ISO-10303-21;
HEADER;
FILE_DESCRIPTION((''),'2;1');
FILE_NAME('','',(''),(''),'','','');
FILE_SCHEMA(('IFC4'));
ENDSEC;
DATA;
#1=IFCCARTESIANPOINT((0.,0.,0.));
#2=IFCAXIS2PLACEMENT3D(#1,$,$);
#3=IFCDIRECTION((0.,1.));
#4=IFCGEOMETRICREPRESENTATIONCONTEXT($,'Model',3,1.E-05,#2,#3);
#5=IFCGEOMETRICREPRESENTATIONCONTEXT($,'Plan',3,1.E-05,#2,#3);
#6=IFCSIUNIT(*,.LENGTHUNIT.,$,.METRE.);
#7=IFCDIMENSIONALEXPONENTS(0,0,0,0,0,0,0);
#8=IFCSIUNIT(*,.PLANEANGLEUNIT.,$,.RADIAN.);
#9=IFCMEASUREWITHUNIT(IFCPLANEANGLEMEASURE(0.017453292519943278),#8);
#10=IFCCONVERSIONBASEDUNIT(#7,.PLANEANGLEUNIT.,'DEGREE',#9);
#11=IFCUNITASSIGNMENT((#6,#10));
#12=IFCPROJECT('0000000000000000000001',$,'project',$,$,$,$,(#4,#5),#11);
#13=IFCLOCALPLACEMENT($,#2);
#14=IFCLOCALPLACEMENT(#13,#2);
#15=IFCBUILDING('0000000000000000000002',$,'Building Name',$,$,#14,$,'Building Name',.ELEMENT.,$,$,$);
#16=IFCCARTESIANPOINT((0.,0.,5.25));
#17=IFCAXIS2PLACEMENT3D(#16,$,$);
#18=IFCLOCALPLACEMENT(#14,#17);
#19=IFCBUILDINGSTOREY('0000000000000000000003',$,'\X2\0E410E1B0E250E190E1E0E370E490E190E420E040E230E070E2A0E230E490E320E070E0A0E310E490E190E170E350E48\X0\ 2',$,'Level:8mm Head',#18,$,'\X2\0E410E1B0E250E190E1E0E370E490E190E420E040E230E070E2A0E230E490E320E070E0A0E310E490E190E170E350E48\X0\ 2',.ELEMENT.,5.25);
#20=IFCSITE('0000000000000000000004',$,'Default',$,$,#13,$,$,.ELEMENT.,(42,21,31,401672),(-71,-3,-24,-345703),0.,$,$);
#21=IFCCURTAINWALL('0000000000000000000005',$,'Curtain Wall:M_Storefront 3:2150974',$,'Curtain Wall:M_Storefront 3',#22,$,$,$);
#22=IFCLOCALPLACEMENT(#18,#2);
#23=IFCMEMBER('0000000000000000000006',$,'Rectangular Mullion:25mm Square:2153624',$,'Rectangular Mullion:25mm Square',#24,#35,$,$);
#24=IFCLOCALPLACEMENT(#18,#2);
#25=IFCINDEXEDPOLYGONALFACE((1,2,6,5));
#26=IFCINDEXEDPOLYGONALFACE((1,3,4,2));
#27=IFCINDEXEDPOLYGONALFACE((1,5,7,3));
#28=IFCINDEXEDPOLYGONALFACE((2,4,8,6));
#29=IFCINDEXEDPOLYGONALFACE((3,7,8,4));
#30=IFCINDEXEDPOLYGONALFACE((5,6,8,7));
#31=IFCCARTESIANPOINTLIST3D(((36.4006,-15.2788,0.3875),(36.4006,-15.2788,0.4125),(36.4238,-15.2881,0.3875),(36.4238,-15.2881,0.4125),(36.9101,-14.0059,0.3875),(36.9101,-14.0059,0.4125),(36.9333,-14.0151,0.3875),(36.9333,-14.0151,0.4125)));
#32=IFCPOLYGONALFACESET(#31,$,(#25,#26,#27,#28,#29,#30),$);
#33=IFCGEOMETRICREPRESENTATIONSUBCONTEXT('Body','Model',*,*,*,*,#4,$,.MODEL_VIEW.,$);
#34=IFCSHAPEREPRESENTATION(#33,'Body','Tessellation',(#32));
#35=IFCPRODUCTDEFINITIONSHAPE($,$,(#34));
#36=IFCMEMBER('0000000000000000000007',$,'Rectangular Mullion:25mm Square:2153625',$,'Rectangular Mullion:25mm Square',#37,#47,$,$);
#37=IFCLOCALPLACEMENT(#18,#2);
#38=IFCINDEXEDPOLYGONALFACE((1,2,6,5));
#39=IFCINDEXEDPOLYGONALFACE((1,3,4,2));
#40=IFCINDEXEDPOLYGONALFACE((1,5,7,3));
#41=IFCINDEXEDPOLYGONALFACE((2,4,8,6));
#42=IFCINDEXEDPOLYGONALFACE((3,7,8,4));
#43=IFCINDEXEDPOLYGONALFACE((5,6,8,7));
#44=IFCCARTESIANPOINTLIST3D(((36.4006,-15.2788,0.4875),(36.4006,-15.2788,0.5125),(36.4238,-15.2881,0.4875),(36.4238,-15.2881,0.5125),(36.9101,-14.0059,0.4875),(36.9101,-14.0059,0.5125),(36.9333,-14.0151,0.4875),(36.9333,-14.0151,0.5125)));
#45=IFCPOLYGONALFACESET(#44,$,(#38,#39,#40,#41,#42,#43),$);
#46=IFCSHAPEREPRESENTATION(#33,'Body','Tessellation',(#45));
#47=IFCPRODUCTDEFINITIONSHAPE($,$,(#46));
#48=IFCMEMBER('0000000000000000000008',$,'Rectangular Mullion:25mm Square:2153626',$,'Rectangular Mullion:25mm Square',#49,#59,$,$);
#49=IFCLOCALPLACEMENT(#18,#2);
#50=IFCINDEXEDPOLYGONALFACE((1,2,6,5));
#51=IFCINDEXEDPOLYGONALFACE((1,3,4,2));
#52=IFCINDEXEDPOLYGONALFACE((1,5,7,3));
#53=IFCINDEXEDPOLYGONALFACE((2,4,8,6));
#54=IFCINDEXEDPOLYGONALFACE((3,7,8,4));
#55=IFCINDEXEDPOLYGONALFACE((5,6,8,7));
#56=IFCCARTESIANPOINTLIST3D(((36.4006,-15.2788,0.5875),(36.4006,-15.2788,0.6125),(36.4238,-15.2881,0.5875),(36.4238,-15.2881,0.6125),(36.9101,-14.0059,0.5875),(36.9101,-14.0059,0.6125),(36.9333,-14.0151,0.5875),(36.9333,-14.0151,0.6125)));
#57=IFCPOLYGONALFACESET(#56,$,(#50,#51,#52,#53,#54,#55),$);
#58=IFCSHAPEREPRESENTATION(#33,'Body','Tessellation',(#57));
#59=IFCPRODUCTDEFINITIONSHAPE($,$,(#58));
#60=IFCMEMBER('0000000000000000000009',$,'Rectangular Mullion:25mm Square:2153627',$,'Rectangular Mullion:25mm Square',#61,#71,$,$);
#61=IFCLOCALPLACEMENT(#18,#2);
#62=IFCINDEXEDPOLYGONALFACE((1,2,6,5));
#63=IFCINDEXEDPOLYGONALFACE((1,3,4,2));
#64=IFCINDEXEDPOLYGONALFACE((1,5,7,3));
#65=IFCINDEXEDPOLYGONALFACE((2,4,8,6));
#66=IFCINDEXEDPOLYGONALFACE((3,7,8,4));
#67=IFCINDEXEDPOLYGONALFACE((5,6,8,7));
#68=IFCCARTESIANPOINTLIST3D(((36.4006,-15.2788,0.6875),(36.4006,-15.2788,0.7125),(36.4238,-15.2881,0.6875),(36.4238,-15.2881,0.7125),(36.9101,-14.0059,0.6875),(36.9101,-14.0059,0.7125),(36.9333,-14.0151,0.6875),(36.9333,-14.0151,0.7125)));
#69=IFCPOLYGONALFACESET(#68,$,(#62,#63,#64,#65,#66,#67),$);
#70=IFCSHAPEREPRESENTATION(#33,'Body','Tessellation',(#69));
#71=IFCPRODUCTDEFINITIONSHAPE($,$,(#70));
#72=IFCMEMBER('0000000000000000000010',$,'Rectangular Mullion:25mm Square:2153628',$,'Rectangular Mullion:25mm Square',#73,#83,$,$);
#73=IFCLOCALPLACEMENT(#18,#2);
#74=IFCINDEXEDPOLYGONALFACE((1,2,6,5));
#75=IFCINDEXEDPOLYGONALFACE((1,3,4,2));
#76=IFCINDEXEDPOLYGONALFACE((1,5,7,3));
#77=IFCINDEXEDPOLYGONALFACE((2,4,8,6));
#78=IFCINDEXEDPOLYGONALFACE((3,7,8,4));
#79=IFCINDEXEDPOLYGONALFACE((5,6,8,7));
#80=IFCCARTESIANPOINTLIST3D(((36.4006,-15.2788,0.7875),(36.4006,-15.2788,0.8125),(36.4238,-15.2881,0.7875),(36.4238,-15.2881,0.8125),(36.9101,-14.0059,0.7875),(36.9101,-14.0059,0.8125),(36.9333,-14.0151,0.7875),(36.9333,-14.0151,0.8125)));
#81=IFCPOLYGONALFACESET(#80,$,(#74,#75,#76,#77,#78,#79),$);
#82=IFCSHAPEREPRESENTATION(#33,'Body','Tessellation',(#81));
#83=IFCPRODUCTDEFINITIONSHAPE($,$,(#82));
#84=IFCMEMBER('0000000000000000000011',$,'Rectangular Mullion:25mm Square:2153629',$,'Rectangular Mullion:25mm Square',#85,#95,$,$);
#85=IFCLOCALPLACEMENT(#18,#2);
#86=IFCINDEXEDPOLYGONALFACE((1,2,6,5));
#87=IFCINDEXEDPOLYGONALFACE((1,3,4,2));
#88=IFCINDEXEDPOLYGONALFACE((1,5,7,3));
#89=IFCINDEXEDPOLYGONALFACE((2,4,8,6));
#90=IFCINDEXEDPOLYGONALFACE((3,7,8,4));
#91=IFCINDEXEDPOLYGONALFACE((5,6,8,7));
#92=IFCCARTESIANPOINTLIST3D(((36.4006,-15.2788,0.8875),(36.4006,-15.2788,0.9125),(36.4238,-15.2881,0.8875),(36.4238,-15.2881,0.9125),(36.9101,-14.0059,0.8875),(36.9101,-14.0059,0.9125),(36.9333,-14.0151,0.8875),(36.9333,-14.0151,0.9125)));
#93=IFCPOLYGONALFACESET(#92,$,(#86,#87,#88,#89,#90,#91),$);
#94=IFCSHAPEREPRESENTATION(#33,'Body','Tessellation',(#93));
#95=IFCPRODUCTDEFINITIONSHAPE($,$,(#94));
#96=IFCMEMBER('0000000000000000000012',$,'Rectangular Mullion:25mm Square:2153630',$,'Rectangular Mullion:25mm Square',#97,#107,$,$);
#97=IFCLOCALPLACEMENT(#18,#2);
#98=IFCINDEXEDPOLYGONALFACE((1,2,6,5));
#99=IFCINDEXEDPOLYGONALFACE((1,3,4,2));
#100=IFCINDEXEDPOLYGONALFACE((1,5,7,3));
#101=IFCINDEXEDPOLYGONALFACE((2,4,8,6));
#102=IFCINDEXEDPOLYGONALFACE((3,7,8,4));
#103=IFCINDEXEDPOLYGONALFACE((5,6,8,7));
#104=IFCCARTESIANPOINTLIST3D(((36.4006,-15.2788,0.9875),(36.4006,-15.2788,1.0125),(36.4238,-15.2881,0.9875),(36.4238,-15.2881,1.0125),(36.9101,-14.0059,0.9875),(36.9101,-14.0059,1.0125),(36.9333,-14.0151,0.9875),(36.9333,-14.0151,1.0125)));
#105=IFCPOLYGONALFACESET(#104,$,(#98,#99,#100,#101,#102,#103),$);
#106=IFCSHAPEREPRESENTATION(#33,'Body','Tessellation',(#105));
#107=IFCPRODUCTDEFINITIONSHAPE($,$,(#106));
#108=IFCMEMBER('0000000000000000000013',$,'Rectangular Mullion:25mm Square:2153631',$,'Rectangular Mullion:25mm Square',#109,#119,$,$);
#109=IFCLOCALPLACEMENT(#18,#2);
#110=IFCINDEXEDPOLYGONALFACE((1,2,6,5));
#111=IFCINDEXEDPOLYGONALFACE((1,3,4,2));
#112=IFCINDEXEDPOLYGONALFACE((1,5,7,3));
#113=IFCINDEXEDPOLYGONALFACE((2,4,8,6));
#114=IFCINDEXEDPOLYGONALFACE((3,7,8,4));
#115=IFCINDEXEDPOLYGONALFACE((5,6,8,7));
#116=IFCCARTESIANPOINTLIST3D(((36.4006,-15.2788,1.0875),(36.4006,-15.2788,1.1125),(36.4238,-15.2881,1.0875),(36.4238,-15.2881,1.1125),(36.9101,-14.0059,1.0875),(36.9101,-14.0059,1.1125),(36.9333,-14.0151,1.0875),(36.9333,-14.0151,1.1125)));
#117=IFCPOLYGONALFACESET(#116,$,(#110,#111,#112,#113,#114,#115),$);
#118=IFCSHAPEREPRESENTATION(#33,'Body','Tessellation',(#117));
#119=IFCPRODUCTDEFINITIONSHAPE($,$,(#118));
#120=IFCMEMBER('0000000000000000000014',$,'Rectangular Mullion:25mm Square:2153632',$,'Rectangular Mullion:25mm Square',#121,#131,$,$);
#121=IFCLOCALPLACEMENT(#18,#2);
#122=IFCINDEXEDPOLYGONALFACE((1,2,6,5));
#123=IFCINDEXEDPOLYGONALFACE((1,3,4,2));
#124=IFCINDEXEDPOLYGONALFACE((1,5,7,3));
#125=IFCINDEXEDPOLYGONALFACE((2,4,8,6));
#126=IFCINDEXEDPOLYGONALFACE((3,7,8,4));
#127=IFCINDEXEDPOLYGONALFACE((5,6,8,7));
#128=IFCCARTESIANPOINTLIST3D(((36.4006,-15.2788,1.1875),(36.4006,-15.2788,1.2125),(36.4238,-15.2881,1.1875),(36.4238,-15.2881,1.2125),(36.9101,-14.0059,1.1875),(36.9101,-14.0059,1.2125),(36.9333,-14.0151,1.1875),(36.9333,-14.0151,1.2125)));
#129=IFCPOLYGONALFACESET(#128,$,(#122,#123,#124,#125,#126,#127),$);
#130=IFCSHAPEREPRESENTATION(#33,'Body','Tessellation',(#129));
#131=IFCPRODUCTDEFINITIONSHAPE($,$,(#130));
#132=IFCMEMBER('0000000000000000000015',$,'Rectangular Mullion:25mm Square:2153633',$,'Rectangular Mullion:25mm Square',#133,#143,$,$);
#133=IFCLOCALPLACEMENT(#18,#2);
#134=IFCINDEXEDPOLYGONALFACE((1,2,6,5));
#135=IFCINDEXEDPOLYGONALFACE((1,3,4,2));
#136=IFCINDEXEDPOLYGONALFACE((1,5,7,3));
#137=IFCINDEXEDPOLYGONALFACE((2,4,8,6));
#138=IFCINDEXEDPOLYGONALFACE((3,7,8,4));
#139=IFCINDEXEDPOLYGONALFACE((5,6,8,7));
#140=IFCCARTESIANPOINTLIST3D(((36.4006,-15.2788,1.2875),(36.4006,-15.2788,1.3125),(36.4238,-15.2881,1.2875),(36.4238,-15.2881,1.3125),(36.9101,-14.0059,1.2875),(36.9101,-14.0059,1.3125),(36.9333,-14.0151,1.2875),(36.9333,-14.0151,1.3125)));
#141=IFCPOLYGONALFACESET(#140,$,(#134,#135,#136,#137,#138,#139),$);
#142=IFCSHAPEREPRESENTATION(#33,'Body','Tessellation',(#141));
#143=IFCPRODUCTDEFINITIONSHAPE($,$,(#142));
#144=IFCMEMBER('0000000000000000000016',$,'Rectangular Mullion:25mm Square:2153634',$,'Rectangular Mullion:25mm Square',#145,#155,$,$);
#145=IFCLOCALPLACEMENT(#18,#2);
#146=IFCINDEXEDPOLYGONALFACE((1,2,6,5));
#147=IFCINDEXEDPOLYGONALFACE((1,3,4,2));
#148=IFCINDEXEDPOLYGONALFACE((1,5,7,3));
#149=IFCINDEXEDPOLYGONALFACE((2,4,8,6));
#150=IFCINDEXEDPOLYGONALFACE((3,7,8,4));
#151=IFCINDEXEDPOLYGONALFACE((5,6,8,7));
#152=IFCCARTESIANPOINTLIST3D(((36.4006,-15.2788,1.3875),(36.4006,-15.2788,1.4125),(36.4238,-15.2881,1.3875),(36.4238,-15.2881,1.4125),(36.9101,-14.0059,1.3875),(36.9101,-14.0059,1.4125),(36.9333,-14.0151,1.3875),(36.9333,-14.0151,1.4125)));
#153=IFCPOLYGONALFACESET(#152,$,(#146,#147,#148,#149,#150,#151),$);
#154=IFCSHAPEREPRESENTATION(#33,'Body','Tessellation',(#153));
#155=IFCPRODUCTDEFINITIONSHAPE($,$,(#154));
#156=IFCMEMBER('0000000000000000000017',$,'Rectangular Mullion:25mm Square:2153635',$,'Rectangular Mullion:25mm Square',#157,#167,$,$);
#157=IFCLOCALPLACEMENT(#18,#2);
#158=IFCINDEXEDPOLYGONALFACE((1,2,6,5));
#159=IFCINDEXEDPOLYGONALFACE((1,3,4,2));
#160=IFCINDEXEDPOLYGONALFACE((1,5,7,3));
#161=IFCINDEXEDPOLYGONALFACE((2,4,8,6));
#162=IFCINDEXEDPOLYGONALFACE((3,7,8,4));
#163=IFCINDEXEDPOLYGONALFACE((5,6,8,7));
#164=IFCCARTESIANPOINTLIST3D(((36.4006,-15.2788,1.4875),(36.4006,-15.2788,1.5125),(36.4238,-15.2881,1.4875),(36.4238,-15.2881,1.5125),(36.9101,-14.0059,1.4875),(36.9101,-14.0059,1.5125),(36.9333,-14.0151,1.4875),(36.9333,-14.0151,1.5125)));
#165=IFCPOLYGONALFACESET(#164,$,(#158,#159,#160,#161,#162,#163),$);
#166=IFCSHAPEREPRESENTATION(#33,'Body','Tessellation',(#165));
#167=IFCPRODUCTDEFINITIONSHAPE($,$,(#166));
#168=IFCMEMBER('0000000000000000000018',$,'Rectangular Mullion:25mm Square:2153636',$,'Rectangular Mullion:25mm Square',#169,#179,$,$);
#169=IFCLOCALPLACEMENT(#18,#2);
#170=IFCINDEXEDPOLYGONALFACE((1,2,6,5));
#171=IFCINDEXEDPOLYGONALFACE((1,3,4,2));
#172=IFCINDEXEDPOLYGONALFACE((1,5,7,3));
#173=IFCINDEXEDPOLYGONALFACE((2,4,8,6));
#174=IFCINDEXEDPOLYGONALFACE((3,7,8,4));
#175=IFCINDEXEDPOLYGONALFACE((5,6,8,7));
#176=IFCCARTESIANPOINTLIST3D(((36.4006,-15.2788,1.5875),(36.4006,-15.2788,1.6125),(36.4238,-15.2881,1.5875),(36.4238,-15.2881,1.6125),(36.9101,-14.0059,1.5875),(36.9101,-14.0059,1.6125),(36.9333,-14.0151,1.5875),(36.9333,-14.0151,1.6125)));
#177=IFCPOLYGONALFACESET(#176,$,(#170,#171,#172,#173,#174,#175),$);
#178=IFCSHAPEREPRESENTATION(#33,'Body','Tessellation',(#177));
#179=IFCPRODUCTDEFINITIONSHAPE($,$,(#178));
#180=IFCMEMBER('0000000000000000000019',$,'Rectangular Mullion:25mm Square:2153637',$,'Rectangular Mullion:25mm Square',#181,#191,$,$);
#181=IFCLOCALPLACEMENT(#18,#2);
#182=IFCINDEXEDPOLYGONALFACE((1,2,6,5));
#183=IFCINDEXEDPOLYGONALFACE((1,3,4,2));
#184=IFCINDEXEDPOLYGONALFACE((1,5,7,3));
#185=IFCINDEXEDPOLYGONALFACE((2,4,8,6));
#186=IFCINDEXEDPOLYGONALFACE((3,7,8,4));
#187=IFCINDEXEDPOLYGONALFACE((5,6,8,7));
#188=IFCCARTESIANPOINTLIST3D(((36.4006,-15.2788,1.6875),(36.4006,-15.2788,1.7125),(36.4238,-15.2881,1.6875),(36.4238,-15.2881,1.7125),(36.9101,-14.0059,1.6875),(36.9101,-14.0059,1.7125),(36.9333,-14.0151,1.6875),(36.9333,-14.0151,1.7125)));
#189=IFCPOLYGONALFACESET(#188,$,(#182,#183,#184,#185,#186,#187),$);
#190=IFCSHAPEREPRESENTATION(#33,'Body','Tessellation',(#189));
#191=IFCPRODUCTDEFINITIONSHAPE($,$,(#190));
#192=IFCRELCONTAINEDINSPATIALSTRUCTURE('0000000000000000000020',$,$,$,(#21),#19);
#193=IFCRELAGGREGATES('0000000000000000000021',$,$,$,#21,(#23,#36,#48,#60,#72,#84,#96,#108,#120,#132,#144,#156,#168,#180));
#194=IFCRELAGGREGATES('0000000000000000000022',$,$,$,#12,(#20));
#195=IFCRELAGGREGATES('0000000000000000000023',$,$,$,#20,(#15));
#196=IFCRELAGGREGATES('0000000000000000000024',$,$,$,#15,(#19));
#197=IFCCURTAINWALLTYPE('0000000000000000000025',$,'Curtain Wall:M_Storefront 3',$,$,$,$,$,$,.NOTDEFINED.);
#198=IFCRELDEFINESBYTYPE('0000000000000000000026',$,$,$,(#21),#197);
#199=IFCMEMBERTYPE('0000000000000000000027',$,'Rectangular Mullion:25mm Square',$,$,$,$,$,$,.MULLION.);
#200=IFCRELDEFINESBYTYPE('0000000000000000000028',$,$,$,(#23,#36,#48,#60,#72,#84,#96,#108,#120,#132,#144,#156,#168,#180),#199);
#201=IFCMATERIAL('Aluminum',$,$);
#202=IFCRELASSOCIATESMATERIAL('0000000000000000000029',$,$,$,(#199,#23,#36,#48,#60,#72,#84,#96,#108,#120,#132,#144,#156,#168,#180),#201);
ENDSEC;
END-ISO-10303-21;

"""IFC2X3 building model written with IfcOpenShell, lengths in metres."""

from ifc_helpers import new_model, entity, si_unit, converted_unit, direction, frame, frame_2d, origin, place, context, subcontext, project, spatial, rectangle, extrude, source, transform, mapped, material, type_object, type_shapes, element, aggregate, save


model = new_model("IFC2X3")

# Units and contexts
model_context = context("Model", 3, precision=1e-05, world=origin(), true_north=direction((0.0, 1.0)))
plan_context = context("Plan", 3, precision=1e-05, world=origin(), true_north=direction((0.0, 1.0)))
body_context = subcontext(model_context, "Body", "Model", "MODEL_VIEW")
ifc_project = project(units=[si_unit("LENGTHUNIT", "METRE"), converted_unit("PLANEANGLEUNIT", "DEGREE", entity("IfcPlaneAngleMeasure", 0.017453292519943278), si_unit("PLANEANGLEUNIT", "RADIAN"), dimensions=[0, 0, 0, 0, 0, 0, 0])], contexts=[model_context, plan_context])

# Site, building, storey
site_placement = place(None, origin())
site = spatial("IfcSite", under=ifc_project, at=site_placement, Name="Default", CompositionType="ELEMENT", RefLatitude=(42, 21, 31, 401672), RefLongitude=(-71, -3, -24, -345703), RefElevation=0.0)
building_placement = place(site_placement, origin())
building = spatial("IfcBuilding", under=site, at=building_placement, Name="Building Name", LongName="Building Name", CompositionType="ELEMENT")
storey_placement = place(building_placement, frame((0.0, 0.0, 5.25)))
storey = spatial("IfcBuildingStorey", under=building, at=storey_placement, Name="แปลนพื้นโครงสร้างชั้นที่ 2", ObjectType="Level:8mm Head", LongName="แปลนพื้นโครงสร้างชั้นที่ 2", CompositionType="ELEMENT", Elevation=5.25)

# Curtain wall, members
curtain_wall_type = type_object("IfcCurtainWallType", Name="Curtain Wall:M_Storefront 3", PredefinedType="NOTDEFINED")
curtain_wall_placement = place(storey_placement, frame((0.0, 0.0, -5.25)))
curtain_wall = element("IfcCurtainWall", 1, at=curtain_wall_placement, inside=storey, type_object=curtain_wall_type, Name="Curtain Wall:M_Storefront 3:2150974", ObjectType="Curtain Wall:M_Storefront 3")
ifc_material_1 = material(Name="Aluminum")
member_type_1 = type_object("IfcMemberType", Name="Rectangular Mullion:25mm Square", PredefinedType="MULLION", material=ifc_material_1)
shared_shape_1 = source(origin(), body_context, "Body", "SweptSolid", [
    extrude(rectangle(XDim=0.025, YDim=0.025, at=frame_2d((0.0, 0.0), x_axis=(1.0, 0.0))), frame((0.0, 0.0, -1.3712), z_axis=(0.0, 0.0, 1.0), x_axis=(-1.0, 0.0, 0.0)), (0.0, 0.0, 1.0), 1.3712),
])
type_shapes(member_type_1, [shared_shape_1])
member_1_placement = place(curtain_wall_placement, frame((36.9217, -14.0105, 5.65), z_axis=(0.371573, 0.928404, 0.0), x_axis=(0.0, 0.0, 1.0)))
member_1 = element("IfcMember", 2, at=member_1_placement, type_object=member_type_1, material=ifc_material_1, Name="Rectangular Mullion:25mm Square:2153624", ObjectType="Rectangular Mullion:25mm Square", context=body_context, shape_type="MappedRepresentation", body=[
    mapped(shared_shape_1, transform((0.0, 0.0, 0.0), scale=1.0)),
])
member_2_placement = place(curtain_wall_placement, frame((36.9217, -14.0105, 5.75), z_axis=(0.371573, 0.928404, 0.0), x_axis=(0.0, 0.0, 1.0)))
member_2 = element("IfcMember", 3, at=member_2_placement, type_object=member_type_1, material=ifc_material_1, Name="Rectangular Mullion:25mm Square:2153625", ObjectType="Rectangular Mullion:25mm Square", context=body_context, shape_type="MappedRepresentation", body=[
    mapped(shared_shape_1, transform((0.0, 0.0, 0.0), scale=1.0)),
])
member_3_placement = place(curtain_wall_placement, frame((36.9217, -14.0105, 5.85), z_axis=(0.371573, 0.928404, 0.0), x_axis=(0.0, 0.0, 1.0)))
member_3 = element("IfcMember", 4, at=member_3_placement, type_object=member_type_1, material=ifc_material_1, Name="Rectangular Mullion:25mm Square:2153626", ObjectType="Rectangular Mullion:25mm Square", context=body_context, shape_type="MappedRepresentation", body=[
    mapped(shared_shape_1, transform((0.0, 0.0, 0.0), scale=1.0)),
])
member_4_placement = place(curtain_wall_placement, frame((36.9217, -14.0105, 5.95), z_axis=(0.371573, 0.928404, 0.0), x_axis=(0.0, 0.0, 1.0)))
member_4 = element("IfcMember", 5, at=member_4_placement, type_object=member_type_1, material=ifc_material_1, Name="Rectangular Mullion:25mm Square:2153627", ObjectType="Rectangular Mullion:25mm Square", context=body_context, shape_type="MappedRepresentation", body=[
    mapped(shared_shape_1, transform((0.0, 0.0, 0.0), scale=1.0)),
])
member_5_placement = place(curtain_wall_placement, frame((36.9217, -14.0105, 6.05), z_axis=(0.371573, 0.928404, 0.0), x_axis=(0.0, 0.0, 1.0)))
member_5 = element("IfcMember", 6, at=member_5_placement, type_object=member_type_1, material=ifc_material_1, Name="Rectangular Mullion:25mm Square:2153628", ObjectType="Rectangular Mullion:25mm Square", context=body_context, shape_type="MappedRepresentation", body=[
    mapped(shared_shape_1, transform((0.0, 0.0, 0.0), scale=1.0)),
])
member_6_placement = place(curtain_wall_placement, frame((36.9217, -14.0105, 6.15), z_axis=(0.371573, 0.928404, 0.0), x_axis=(0.0, 0.0, 1.0)))
member_6 = element("IfcMember", 7, at=member_6_placement, type_object=member_type_1, material=ifc_material_1, Name="Rectangular Mullion:25mm Square:2153629", ObjectType="Rectangular Mullion:25mm Square", context=body_context, shape_type="MappedRepresentation", body=[
    mapped(shared_shape_1, transform((0.0, 0.0, 0.0), scale=1.0)),
])
member_7_placement = place(curtain_wall_placement, frame((36.9217, -14.0105, 6.25), z_axis=(0.371573, 0.928404, 0.0), x_axis=(0.0, 0.0, 1.0)))
member_7 = element("IfcMember", 8, at=member_7_placement, type_object=member_type_1, material=ifc_material_1, Name="Rectangular Mullion:25mm Square:2153630", ObjectType="Rectangular Mullion:25mm Square", context=body_context, shape_type="MappedRepresentation", body=[
    mapped(shared_shape_1, transform((0.0, 0.0, 0.0), scale=1.0)),
])
member_8_placement = place(curtain_wall_placement, frame((36.9217, -14.0105, 6.35), z_axis=(0.371573, 0.928404, 0.0), x_axis=(0.0, 0.0, 1.0)))
member_8 = element("IfcMember", 9, at=member_8_placement, type_object=member_type_1, material=ifc_material_1, Name="Rectangular Mullion:25mm Square:2153631", ObjectType="Rectangular Mullion:25mm Square", context=body_context, shape_type="MappedRepresentation", body=[
    mapped(shared_shape_1, transform((0.0, 0.0, 0.0), scale=1.0)),
])
member_9_placement = place(curtain_wall_placement, frame((36.9217, -14.0105, 6.45), z_axis=(0.371573, 0.928404, 0.0), x_axis=(0.0, 0.0, 1.0)))
member_9 = element("IfcMember", 10, at=member_9_placement, type_object=member_type_1, material=ifc_material_1, Name="Rectangular Mullion:25mm Square:2153632", ObjectType="Rectangular Mullion:25mm Square", context=body_context, shape_type="MappedRepresentation", body=[
    mapped(shared_shape_1, transform((0.0, 0.0, 0.0), scale=1.0)),
])
member_10_placement = place(curtain_wall_placement, frame((36.9217, -14.0105, 6.55), z_axis=(0.371573, 0.928404, 0.0), x_axis=(0.0, 0.0, 1.0)))
member_10 = element("IfcMember", 11, at=member_10_placement, type_object=member_type_1, material=ifc_material_1, Name="Rectangular Mullion:25mm Square:2153633", ObjectType="Rectangular Mullion:25mm Square", context=body_context, shape_type="MappedRepresentation", body=[
    mapped(shared_shape_1, transform((0.0, 0.0, 0.0), scale=1.0)),
])
member_11_placement = place(curtain_wall_placement, frame((36.9217, -14.0105, 6.65), z_axis=(0.371573, 0.928404, 0.0), x_axis=(0.0, 0.0, 1.0)))
member_11 = element("IfcMember", 12, at=member_11_placement, type_object=member_type_1, material=ifc_material_1, Name="Rectangular Mullion:25mm Square:2153634", ObjectType="Rectangular Mullion:25mm Square", context=body_context, shape_type="MappedRepresentation", body=[
    mapped(shared_shape_1, transform((0.0, 0.0, 0.0), scale=1.0)),
])
member_12_placement = place(curtain_wall_placement, frame((36.9217, -14.0105, 6.75), z_axis=(0.371573, 0.928404, 0.0), x_axis=(0.0, 0.0, 1.0)))
member_12 = element("IfcMember", 13, at=member_12_placement, type_object=member_type_1, material=ifc_material_1, Name="Rectangular Mullion:25mm Square:2153635", ObjectType="Rectangular Mullion:25mm Square", context=body_context, shape_type="MappedRepresentation", body=[
    mapped(shared_shape_1, transform((0.0, 0.0, 0.0), scale=1.0)),
])
member_13_placement = place(curtain_wall_placement, frame((36.9217, -14.0105, 6.85), z_axis=(0.371573, 0.928404, 0.0), x_axis=(0.0, 0.0, 1.0)))
member_13 = element("IfcMember", 14, at=member_13_placement, type_object=member_type_1, material=ifc_material_1, Name="Rectangular Mullion:25mm Square:2153636", ObjectType="Rectangular Mullion:25mm Square", context=body_context, shape_type="MappedRepresentation", body=[
    mapped(shared_shape_1, transform((0.0, 0.0, 0.0), scale=1.0)),
])
member_14_placement = place(curtain_wall_placement, frame((36.9217, -14.0105, 6.95), z_axis=(0.371573, 0.928404, 0.0), x_axis=(0.0, 0.0, 1.0)))
member_14 = element("IfcMember", 15, at=member_14_placement, type_object=member_type_1, material=ifc_material_1, Name="Rectangular Mullion:25mm Square:2153637", ObjectType="Rectangular Mullion:25mm Square", context=body_context, shape_type="MappedRepresentation", body=[
    mapped(shared_shape_1, transform((0.0, 0.0, 0.0), scale=1.0)),
])
aggregate(curtain_wall, [member_1, member_2, member_3, member_4, member_5, member_6, member_7, member_8, member_9, member_10, member_11, member_12, member_13, member_14])

save(model, "model.ifc")
